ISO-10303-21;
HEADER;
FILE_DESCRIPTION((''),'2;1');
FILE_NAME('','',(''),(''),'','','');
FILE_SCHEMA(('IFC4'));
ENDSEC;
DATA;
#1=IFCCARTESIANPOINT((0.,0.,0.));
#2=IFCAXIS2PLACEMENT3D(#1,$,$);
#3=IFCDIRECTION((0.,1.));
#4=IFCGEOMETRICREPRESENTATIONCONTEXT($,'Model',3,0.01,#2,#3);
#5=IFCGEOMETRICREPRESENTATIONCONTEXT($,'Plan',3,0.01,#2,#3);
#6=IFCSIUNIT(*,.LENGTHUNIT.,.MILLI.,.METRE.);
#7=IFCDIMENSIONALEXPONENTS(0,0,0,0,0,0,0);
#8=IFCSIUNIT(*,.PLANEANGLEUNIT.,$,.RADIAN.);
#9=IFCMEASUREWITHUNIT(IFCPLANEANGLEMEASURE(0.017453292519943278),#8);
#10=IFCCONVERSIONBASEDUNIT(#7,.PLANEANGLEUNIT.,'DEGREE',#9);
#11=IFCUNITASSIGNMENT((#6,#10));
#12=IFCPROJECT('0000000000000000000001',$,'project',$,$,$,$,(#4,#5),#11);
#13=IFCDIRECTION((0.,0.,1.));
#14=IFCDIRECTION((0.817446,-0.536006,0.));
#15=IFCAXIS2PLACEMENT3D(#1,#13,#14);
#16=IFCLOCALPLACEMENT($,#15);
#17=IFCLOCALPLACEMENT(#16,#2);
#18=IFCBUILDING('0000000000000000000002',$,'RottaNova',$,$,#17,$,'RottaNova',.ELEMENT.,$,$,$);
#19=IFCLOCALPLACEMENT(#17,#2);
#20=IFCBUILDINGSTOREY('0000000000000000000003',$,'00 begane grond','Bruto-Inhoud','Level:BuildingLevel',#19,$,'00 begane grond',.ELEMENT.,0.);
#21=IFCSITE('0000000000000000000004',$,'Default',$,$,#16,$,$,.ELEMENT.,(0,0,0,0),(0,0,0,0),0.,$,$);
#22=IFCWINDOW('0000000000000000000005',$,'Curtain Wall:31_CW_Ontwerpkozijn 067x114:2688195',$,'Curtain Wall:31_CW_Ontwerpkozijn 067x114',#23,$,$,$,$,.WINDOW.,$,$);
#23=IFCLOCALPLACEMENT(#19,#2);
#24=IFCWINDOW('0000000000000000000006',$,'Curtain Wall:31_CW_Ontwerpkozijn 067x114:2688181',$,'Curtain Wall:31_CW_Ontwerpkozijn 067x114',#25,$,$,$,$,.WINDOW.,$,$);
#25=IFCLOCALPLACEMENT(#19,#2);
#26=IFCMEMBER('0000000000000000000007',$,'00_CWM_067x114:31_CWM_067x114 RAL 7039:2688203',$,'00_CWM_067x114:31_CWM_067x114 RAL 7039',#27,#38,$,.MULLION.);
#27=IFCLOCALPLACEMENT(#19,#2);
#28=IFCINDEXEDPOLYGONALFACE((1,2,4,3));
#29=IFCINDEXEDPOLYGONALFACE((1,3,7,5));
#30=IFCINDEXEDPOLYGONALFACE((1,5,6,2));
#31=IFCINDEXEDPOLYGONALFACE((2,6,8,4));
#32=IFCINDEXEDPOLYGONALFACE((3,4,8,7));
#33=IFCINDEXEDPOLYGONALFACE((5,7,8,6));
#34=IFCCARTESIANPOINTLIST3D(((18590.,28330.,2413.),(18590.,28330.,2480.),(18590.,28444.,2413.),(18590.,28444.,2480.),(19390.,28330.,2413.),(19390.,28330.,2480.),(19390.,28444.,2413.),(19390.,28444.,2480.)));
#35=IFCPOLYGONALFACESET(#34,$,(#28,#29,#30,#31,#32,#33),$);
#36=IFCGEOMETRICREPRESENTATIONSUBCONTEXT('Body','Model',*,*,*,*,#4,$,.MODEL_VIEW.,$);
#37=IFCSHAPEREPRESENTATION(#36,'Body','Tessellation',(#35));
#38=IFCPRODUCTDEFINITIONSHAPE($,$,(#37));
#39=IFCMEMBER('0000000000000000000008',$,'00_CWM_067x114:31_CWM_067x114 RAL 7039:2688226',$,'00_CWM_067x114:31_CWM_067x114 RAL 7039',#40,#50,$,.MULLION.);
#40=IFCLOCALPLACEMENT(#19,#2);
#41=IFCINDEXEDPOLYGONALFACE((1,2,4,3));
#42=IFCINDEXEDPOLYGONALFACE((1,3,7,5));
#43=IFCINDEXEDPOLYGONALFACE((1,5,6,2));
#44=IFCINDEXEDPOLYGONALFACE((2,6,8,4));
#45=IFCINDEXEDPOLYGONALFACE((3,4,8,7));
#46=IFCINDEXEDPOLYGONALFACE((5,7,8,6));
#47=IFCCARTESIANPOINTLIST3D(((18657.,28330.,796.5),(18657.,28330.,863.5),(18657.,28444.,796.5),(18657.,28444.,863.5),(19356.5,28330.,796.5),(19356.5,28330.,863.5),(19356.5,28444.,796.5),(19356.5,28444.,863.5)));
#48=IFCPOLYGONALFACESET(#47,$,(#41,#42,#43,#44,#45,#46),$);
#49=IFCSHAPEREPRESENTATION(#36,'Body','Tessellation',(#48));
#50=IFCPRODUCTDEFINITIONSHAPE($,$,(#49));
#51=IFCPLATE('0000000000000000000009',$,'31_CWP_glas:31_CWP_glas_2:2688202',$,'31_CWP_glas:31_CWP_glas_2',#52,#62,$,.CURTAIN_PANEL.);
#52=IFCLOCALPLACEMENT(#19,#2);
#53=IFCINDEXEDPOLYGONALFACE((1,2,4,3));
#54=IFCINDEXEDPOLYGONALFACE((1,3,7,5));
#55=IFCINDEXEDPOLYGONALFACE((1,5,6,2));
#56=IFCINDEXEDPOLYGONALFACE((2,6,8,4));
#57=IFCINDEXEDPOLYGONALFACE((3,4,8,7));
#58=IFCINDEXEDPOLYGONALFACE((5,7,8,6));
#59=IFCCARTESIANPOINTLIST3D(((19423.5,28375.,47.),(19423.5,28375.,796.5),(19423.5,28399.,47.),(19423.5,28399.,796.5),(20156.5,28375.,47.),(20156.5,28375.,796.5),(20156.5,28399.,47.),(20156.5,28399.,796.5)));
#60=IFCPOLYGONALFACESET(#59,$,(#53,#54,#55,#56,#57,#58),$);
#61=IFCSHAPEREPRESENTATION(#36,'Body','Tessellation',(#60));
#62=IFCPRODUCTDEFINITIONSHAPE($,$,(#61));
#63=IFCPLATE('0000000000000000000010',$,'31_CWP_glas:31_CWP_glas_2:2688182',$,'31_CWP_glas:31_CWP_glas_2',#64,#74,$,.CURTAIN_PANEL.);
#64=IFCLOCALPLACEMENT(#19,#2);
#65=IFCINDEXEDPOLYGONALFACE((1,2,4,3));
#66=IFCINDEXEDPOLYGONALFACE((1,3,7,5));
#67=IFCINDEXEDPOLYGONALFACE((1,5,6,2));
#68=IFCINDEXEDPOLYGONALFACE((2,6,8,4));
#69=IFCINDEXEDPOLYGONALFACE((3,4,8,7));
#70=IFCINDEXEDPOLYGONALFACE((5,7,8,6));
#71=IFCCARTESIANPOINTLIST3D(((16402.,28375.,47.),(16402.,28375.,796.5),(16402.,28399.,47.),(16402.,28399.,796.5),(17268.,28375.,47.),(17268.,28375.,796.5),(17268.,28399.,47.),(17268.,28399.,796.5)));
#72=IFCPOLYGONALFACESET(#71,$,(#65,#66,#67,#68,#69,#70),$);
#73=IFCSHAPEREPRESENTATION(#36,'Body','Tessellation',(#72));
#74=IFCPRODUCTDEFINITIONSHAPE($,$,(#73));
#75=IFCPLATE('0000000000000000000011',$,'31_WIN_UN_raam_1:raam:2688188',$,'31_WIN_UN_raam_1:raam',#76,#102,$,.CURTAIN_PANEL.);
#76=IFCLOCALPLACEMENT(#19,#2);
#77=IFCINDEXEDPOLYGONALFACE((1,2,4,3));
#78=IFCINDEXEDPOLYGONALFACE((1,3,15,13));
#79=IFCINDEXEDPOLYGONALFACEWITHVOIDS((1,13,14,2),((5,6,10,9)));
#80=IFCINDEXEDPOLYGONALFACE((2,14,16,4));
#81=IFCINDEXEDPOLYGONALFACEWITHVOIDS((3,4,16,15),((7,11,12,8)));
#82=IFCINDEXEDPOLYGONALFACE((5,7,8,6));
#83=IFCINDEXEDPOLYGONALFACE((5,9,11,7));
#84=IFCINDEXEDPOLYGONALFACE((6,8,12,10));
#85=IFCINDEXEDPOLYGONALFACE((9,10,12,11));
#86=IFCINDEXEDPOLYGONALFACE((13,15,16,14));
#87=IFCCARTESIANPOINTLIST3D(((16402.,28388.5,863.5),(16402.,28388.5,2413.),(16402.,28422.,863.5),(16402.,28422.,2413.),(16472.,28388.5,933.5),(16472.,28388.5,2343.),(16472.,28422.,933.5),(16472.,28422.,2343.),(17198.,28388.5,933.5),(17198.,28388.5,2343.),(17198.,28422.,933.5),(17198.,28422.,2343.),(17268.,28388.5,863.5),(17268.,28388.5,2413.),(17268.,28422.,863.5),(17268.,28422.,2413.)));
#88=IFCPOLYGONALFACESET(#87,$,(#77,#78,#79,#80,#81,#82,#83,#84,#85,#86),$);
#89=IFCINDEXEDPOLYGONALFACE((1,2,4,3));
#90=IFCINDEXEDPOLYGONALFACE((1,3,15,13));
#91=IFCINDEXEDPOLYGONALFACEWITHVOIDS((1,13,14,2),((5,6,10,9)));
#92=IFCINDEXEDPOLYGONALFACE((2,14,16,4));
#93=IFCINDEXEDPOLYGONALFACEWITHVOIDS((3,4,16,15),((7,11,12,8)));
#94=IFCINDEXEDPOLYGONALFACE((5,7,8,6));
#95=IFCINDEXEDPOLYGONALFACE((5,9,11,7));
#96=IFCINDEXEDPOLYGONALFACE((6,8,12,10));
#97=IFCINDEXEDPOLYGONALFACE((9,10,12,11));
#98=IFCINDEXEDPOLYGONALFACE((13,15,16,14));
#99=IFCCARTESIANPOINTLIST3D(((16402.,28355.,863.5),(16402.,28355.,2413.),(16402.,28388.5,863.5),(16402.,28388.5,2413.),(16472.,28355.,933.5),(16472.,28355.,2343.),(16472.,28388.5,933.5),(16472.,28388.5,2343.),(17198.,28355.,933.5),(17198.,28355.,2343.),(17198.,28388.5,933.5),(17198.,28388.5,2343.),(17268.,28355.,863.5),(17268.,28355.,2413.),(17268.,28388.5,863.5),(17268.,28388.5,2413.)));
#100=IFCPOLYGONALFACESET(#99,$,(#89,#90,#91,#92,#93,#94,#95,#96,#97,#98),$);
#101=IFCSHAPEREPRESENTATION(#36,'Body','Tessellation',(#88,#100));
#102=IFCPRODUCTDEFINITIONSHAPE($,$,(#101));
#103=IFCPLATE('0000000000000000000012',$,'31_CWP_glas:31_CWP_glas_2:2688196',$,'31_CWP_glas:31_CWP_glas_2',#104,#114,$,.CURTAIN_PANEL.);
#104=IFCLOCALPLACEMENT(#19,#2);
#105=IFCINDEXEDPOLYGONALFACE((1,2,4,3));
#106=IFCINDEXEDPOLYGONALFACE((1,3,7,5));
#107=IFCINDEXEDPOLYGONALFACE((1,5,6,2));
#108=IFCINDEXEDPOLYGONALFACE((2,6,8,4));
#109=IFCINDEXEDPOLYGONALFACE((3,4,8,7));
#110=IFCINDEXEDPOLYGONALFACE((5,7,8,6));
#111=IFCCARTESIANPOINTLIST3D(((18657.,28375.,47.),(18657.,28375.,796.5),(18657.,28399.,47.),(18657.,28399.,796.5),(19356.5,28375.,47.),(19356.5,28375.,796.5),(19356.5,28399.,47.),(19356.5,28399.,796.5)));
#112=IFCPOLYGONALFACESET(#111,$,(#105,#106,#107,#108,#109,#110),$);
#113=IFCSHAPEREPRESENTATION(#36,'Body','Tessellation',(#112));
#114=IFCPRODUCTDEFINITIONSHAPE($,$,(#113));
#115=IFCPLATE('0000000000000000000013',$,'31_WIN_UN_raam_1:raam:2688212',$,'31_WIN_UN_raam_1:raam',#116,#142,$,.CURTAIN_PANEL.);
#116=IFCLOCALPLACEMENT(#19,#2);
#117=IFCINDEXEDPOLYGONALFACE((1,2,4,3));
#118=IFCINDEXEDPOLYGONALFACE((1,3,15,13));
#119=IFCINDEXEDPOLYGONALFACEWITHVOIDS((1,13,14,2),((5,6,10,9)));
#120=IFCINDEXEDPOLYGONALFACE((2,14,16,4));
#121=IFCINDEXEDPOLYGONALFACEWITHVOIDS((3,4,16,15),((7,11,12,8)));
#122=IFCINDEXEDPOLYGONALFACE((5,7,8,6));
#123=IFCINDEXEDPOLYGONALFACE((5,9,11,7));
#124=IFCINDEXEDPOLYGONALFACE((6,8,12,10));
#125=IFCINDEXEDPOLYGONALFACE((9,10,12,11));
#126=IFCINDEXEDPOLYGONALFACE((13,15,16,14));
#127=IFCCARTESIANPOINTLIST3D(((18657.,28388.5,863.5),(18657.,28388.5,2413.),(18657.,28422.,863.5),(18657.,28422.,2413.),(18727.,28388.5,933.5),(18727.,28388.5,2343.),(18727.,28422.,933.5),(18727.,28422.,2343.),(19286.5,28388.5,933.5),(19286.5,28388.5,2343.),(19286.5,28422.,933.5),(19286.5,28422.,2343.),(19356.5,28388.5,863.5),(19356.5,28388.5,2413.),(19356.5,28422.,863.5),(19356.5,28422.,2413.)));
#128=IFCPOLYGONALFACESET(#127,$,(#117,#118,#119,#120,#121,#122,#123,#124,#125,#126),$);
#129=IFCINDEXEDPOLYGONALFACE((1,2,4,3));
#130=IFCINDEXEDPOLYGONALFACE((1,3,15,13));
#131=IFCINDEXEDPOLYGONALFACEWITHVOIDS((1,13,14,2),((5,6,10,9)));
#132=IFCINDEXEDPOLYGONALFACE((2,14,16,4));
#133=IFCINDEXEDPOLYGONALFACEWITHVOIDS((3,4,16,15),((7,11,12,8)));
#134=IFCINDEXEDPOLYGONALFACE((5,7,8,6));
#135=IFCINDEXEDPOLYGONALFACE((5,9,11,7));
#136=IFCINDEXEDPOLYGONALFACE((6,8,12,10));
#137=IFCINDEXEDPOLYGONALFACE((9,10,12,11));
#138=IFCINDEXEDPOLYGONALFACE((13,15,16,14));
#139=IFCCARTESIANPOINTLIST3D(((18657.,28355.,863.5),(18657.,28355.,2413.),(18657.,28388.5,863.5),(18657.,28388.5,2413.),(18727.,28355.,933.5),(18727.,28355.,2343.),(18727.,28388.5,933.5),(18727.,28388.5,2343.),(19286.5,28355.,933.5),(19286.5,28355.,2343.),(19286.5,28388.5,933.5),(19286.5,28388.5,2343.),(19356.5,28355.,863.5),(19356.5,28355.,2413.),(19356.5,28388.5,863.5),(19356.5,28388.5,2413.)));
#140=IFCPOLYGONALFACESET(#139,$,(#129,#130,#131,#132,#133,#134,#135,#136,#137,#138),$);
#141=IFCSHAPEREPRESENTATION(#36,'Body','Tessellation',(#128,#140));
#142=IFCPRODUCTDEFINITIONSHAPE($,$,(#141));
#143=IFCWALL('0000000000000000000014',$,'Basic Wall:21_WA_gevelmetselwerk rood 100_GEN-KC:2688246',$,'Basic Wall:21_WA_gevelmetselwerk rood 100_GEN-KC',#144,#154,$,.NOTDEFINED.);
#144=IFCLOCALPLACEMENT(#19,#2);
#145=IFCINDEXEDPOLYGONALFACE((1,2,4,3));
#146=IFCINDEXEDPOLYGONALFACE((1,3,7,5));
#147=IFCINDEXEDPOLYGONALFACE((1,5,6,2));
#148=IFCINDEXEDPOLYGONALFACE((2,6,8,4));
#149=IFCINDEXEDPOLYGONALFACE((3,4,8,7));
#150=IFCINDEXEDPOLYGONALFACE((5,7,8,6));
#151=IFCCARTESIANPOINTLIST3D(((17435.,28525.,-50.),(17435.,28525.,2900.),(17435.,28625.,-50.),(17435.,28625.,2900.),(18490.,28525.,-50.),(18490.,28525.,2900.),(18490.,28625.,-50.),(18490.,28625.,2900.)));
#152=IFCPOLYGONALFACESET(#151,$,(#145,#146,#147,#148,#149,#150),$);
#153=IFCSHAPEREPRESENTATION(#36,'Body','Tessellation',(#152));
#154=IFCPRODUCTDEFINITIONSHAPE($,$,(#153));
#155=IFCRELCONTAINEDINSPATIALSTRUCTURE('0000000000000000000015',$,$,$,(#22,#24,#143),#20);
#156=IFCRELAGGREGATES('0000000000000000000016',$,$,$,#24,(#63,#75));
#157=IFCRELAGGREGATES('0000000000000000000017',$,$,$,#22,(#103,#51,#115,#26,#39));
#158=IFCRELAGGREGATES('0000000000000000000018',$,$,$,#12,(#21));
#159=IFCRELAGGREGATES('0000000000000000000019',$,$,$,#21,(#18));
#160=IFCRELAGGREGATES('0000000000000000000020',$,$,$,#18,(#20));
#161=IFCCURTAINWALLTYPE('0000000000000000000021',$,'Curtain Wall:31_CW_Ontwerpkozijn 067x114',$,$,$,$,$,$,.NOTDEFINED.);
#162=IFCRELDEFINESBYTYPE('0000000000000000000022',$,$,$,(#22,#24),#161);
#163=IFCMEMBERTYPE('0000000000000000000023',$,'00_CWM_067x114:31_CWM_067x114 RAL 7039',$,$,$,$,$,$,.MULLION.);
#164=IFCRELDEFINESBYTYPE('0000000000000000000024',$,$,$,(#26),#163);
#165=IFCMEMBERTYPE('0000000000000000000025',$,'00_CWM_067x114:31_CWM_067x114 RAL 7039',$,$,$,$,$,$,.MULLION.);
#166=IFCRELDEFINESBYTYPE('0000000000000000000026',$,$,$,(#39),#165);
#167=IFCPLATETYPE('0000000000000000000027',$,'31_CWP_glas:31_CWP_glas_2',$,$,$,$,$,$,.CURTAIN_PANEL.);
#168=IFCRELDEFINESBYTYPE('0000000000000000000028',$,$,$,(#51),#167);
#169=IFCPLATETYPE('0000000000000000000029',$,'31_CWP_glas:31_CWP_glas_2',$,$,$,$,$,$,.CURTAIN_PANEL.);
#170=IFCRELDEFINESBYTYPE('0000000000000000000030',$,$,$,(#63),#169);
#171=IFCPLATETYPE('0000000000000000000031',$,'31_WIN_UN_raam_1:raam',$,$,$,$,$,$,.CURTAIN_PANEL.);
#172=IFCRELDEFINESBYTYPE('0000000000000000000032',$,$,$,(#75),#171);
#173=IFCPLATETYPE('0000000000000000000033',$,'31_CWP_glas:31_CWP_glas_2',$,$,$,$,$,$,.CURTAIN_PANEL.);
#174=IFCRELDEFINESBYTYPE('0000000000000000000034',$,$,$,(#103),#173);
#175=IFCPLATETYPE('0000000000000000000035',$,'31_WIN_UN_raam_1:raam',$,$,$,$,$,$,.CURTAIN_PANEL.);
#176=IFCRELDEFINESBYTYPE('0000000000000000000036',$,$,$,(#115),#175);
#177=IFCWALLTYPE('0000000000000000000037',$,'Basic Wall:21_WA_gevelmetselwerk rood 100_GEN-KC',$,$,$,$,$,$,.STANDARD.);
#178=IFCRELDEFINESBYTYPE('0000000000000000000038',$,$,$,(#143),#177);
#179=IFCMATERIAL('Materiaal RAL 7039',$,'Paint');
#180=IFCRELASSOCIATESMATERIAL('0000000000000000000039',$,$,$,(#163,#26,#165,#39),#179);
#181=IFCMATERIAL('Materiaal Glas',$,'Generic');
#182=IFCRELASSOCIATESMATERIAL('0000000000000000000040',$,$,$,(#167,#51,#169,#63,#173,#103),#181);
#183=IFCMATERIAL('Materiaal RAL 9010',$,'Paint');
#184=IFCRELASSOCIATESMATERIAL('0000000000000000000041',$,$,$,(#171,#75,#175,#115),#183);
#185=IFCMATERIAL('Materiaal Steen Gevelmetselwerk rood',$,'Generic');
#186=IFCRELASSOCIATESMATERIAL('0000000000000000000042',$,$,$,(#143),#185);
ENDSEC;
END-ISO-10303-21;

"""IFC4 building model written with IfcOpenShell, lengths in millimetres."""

from ifc_helpers import new_model, entity, si_unit, converted_unit, direction, frame, origin, place, context, subcontext, project, spatial, indexed_curve, outline, extrude, source, transform, mapped, material, type_object, type_shapes, element, aggregate, save


model = new_model("IFC4")

# Units and contexts
model_context = context("Model", 3, precision=0.01, world=origin(), true_north=direction((0.0, 1.0)))
plan_context = context("Plan", 3, precision=0.01, world=origin(), true_north=direction((0.0, 1.0)))
body_context = subcontext(model_context, "Body", "Model", "MODEL_VIEW")
ifc_project = project(units=[si_unit("LENGTHUNIT", "METRE", prefix="MILLI"), converted_unit("PLANEANGLEUNIT", "DEGREE", entity("IfcPlaneAngleMeasure", 0.017453292519943278), si_unit("PLANEANGLEUNIT", "RADIAN"), dimensions=[0, 0, 0, 0, 0, 0, 0])], contexts=[model_context, plan_context])

# Site, building, storey
site_placement = place(None, frame((0.0, 0.0, 0.0), z_axis=(0.0, 0.0, 1.0), x_axis=(0.817446, -0.536006, 0.0)))
site = spatial("IfcSite", under=ifc_project, at=site_placement, Name="Default", CompositionType="ELEMENT", RefLatitude=(0, 0, 0, 0), RefLongitude=(0, 0, 0, 0), RefElevation=0.0)
building_placement = place(site_placement, origin())
building = spatial("IfcBuilding", under=site, at=building_placement, Name="RottaNova", LongName="RottaNova", CompositionType="ELEMENT")
storey_placement = place(building_placement, origin())
storey = spatial("IfcBuildingStorey", under=building, at=storey_placement, Name="00 begane grond", Description="Bruto-Inhoud", ObjectType="Level:BuildingLevel", LongName="00 begane grond", CompositionType="ELEMENT", Elevation=0.0)

# Windows
curtain_wall_type = type_object("IfcCurtainWallType", Name="Curtain Wall:31_CW_Ontwerpkozijn 067x114", PredefinedType="NOTDEFINED")
window_1_placement = place(storey_placement, origin())
window_1 = element("IfcWindow", 1, at=window_1_placement, inside=storey, type_object=curtain_wall_type, Name="Curtain Wall:31_CW_Ontwerpkozijn 067x114:2688195", ObjectType="Curtain Wall:31_CW_Ontwerpkozijn 067x114", PredefinedType="WINDOW")
ifc_material_1 = material(Name="Materiaal RAL 7039", Category="Paint")
window_2_placement = place(storey_placement, origin())
window_2 = element("IfcWindow", 2, at=window_2_placement, inside=storey, type_object=curtain_wall_type, Name="Curtain Wall:31_CW_Ontwerpkozijn 067x114:2688181", ObjectType="Curtain Wall:31_CW_Ontwerpkozijn 067x114", PredefinedType="WINDOW")

# Members
member_type_1 = type_object("IfcMemberType", Name="00_CWM_067x114:31_CWM_067x114 RAL 7039", PredefinedType="MULLION", material=ifc_material_1)
shared_shape_1 = source(origin(), body_context, "Body", "SweptSolid", [
    extrude(outline(indexed_curve([(-33.5, -57.0), (33.5, -57.0), (33.5, 57.0), (-33.5, 57.0), (-33.5, -57.0)], self_intersect=False)), frame((-33.5, -57.0, -800.0), z_axis=(0.0, 0.0, 1.0), x_axis=(-1.0, 0.0, 0.0)), (0.0, 0.0, 1.0), 800.0),
])
type_shapes(member_type_1, [shared_shape_1])
member_1_placement = place(window_1_placement, frame((19390.0, 28330.0, 2480.0), z_axis=(1.0, 0.0, 0.0), x_axis=(0.0, 0.0, 1.0)))
member_1 = element("IfcMember", 3, at=member_1_placement, type_object=member_type_1, material=ifc_material_1, Name="00_CWM_067x114:31_CWM_067x114 RAL 7039:2688203", ObjectType="00_CWM_067x114:31_CWM_067x114 RAL 7039", PredefinedType="MULLION", context=body_context, shape_type="MappedRepresentation", body=[
    mapped(shared_shape_1, transform((0.0, 0.0, 0.0), scale=1.0)),
])
member_type_2 = type_object("IfcMemberType", Name="00_CWM_067x114:31_CWM_067x114 RAL 7039", PredefinedType="MULLION", material=ifc_material_1)
shared_shape_2 = source(origin(), body_context, "Body", "SweptSolid", [
    extrude(outline(indexed_curve([(-33.5, -57.0), (33.5, -57.0), (33.5, 57.0), (-33.5, 57.0), (-33.5, -57.0)], self_intersect=False)), frame((0.0, -57.0, -699.5), z_axis=(0.0, 0.0, 1.0), x_axis=(-1.0, 0.0, 0.0)), (0.0, 0.0, 1.0), 699.5),
])
type_shapes(member_type_2, [shared_shape_2])
member_2_placement = place(window_1_placement, frame((19356.5, 28330.0, 830.0), z_axis=(1.0, 0.0, 0.0), x_axis=(0.0, 0.0, 1.0)))
member_2 = element("IfcMember", 4, at=member_2_placement, type_object=member_type_2, material=ifc_material_1, Name="00_CWM_067x114:31_CWM_067x114 RAL 7039:2688226", ObjectType="00_CWM_067x114:31_CWM_067x114 RAL 7039", PredefinedType="MULLION", context=body_context, shape_type="MappedRepresentation", body=[
    mapped(shared_shape_2, transform((0.0, 0.0, 0.0), scale=1.0)),
])

# Plates
ifc_material_2 = material(Name="Materiaal Glas", Category="Generic")
plate_type_1 = type_object("IfcPlateType", Name="31_CWP_glas:31_CWP_glas_2", PredefinedType="CURTAIN_PANEL", material=ifc_material_2)
shared_shape_3 = source(origin(), body_context, "Body", "SweptSolid", [
    extrude(outline(indexed_curve([(-12.0, -366.5), (12.0, -366.5), (12.0, 366.5), (-12.0, 366.5), (-12.0, -366.5)], self_intersect=False)), frame((0.0, 57.0, 0.0), z_axis=(0.0, 0.0, 1.0), x_axis=(0.0, 1.0, 0.0)), (0.0, 0.0, 1.0), 749.5),
])
type_shapes(plate_type_1, [shared_shape_3])
plate_1_placement = place(window_1_placement, frame((19790.0, 28330.0, 47.0)))
plate_1 = element("IfcPlate", 5, at=plate_1_placement, type_object=plate_type_1, material=ifc_material_2, Name="31_CWP_glas:31_CWP_glas_2:2688202", ObjectType="31_CWP_glas:31_CWP_glas_2", PredefinedType="CURTAIN_PANEL", context=body_context, shape_type="MappedRepresentation", body=[
    mapped(shared_shape_3, transform((0.0, 0.0, 0.0), scale=1.0)),
])
plate_type_2 = type_object("IfcPlateType", Name="31_CWP_glas:31_CWP_glas_2", PredefinedType="CURTAIN_PANEL", material=ifc_material_2)
shared_shape_4 = source(origin(), body_context, "Body", "SweptSolid", [
    extrude(outline(indexed_curve([(-12.0, -433.0), (12.0, -433.0), (12.0, 433.0), (-12.0, 433.0), (-12.0, -433.0)], self_intersect=False)), frame((0.0, -57.0, 0.0), z_axis=(0.0, 0.0, 1.0), x_axis=(0.0, 1.0, 0.0)), (0.0, 0.0, 1.0), 749.5),
])
type_shapes(plate_type_2, [shared_shape_4])
plate_2_placement = place(window_2_placement, frame((16835.0, 28330.0, 47.0), z_axis=(0.0, 0.0, 1.0), x_axis=(-1.0, 0.0, 0.0)))
plate_2 = element("IfcPlate", 6, at=plate_2_placement, type_object=plate_type_2, material=ifc_material_2, Name="31_CWP_glas:31_CWP_glas_2:2688182", ObjectType="31_CWP_glas:31_CWP_glas_2", PredefinedType="CURTAIN_PANEL", context=body_context, shape_type="MappedRepresentation", body=[
    mapped(shared_shape_4, transform((0.0, 0.0, 0.0), scale=1.0)),
])
ifc_material_3 = material(Name="Materiaal RAL 9010", Category="Paint")
plate_type_3 = type_object("IfcPlateType", Name="31_WIN_UN_raam_1:raam", PredefinedType="CURTAIN_PANEL", material=ifc_material_3)
shared_shape_5 = source(origin(), body_context, "Body", "SweptSolid", [
    extrude(outline(indexed_curve([(-433.0, -774.7), (433.0, -774.7), (433.0, 774.7), (-433.0, 774.7), (-433.0, -774.7)], self_intersect=False), holes=[indexed_curve([(-363.0, 704.7), (363.0, 704.7), (363.0, -704.8), (-363.0, -704.8), (-363.0, 704.7)], self_intersect=False)]), frame((0.0, -92.0, 774.8), z_axis=(0.0, 1.0, 0.0), x_axis=(1.0, 0.0, 0.0)), (0.0, 0.0, 1.0), 33.5),
    extrude(outline(indexed_curve([(-433.0, -774.7), (433.0, -774.7), (433.0, 774.7), (-433.0, 774.7), (-433.0, -774.7)], self_intersect=False), holes=[indexed_curve([(-363.0, 704.7), (363.0, 704.7), (363.0, -704.8), (-363.0, -704.8), (-363.0, 704.7)], self_intersect=False)]), frame((0.0, -58.5, 774.8), z_axis=(0.0, 1.0, 0.0), x_axis=(1.0, 0.0, 0.0)), (0.0, 0.0, 1.0), 33.5),
])
type_shapes(plate_type_3, [shared_shape_5])
plate_3_placement = place(window_2_placement, frame((16835.0, 28330.0, 863.5), z_axis=(0.0, 0.0, 1.0), x_axis=(-1.0, 0.0, 0.0)))
plate_3 = element("IfcPlate", 7, at=plate_3_placement, type_object=plate_type_3, material=ifc_material_3, Name="31_WIN_UN_raam_1:raam:2688188", ObjectType="31_WIN_UN_raam_1:raam", PredefinedType="CURTAIN_PANEL", context=body_context, shape_type="MappedRepresentation", body=[
    mapped(shared_shape_5, transform((0.0, 0.0, 0.0), scale=1.0)),
])
aggregate(window_2, [plate_2, plate_3])
plate_type_4 = type_object("IfcPlateType", Name="31_CWP_glas:31_CWP_glas_2", PredefinedType="CURTAIN_PANEL", material=ifc_material_2)
shared_shape_6 = source(origin(), body_context, "Body", "SweptSolid", [
    extrude(outline(indexed_curve([(-12.0, -349.8), (12.0, -349.8), (12.0, 349.8), (-12.0, 349.8), (-12.0, -349.8)], self_intersect=False)), frame((0.0, 57.0, 0.0), z_axis=(0.0, 0.0, 1.0), x_axis=(0.0, 1.0, 0.0)), (0.0, 0.0, 1.0), 749.5),
])
type_shapes(plate_type_4, [shared_shape_6])
plate_4_placement = place(window_1_placement, frame((19006.8, 28330.0, 47.0)))
plate_4 = element("IfcPlate", 8, at=plate_4_placement, type_object=plate_type_4, material=ifc_material_2, Name="31_CWP_glas:31_CWP_glas_2:2688196", ObjectType="31_CWP_glas:31_CWP_glas_2", PredefinedType="CURTAIN_PANEL", context=body_context, shape_type="MappedRepresentation", body=[
    mapped(shared_shape_6, transform((0.0, 0.0, 0.0), scale=1.0)),
])
plate_type_5 = type_object("IfcPlateType", Name="31_WIN_UN_raam_1:raam", PredefinedType="CURTAIN_PANEL", material=ifc_material_3)
shared_shape_7 = source(origin(), body_context, "Body", "SweptSolid", [
    extrude(outline(indexed_curve([(-349.7, -774.8), (349.7, -774.8), (349.7, 774.8), (-349.7, 774.8), (-349.7, -774.8)], self_intersect=False), holes=[indexed_curve([(-279.7, 704.8), (279.7, 704.8), (279.7, -704.8), (-279.7, -704.8), (-279.7, 704.8)], self_intersect=False)]), frame((0.0, 58.5, 774.8), z_axis=(0.0, 1.0, 0.0), x_axis=(1.0, 0.0, 0.0)), (0.0, 0.0, 1.0), 33.5),
    extrude(outline(indexed_curve([(-349.7, -774.8), (349.7, -774.8), (349.7, 774.8), (-349.7, 774.8), (-349.7, -774.8)], self_intersect=False), holes=[indexed_curve([(-279.7, 704.7), (279.7, 704.7), (279.7, -704.8), (-279.7, -704.8), (-279.7, 704.7)], self_intersect=False)]), frame((0.0, 25.0, 774.8), z_axis=(0.0, 1.0, 0.0), x_axis=(1.0, 0.0, 0.0)), (0.0, 0.0, 1.0), 33.5),
])
type_shapes(plate_type_5, [shared_shape_7])
plate_5_placement = place(window_1_placement, frame((19006.8, 28330.0, 863.5)))
plate_5 = element("IfcPlate", 9, at=plate_5_placement, type_object=plate_type_5, material=ifc_material_3, Name="31_WIN_UN_raam_1:raam:2688212", ObjectType="31_WIN_UN_raam_1:raam", PredefinedType="CURTAIN_PANEL", context=body_context, shape_type="MappedRepresentation", body=[
    mapped(shared_shape_7, transform((0.0, 0.0, 0.0), scale=1.0)),
])
aggregate(window_1, [plate_4, plate_1, plate_5, member_1, member_2])

# Wall
ifc_material_4 = material(Name="Materiaal Steen Gevelmetselwerk rood", Category="Generic")
wall_type_1 = type_object("IfcWallType", Name="Basic Wall:21_WA_gevelmetselwerk rood 100_GEN-KC", PredefinedType="STANDARD")
wall_1_placement = place(storey_placement, frame((18490.0, 28575.0, -50.0), z_axis=(0.0, 0.0, 1.0), x_axis=(-1.0, 0.0, 0.0)))
element("IfcWall", 10, at=wall_1_placement, inside=storey, type_object=wall_type_1, material=ifc_material_4, Name="Basic Wall:21_WA_gevelmetselwerk rood 100_GEN-KC:2688246", ObjectType="Basic Wall:21_WA_gevelmetselwerk rood 100_GEN-KC", PredefinedType="NOTDEFINED", context=body_context, shape_type="SweptSolid", body=[
    extrude(outline(indexed_curve([(1055.0, 50.0), (0.0, 50.0), (0.0, -50.0), (1055.0, -50.0), (1055.0, 50.0)], self_intersect=False)), origin(), (0.0, 0.0, 1.0), 2950.0),
])

save(model, "model.ifc")
